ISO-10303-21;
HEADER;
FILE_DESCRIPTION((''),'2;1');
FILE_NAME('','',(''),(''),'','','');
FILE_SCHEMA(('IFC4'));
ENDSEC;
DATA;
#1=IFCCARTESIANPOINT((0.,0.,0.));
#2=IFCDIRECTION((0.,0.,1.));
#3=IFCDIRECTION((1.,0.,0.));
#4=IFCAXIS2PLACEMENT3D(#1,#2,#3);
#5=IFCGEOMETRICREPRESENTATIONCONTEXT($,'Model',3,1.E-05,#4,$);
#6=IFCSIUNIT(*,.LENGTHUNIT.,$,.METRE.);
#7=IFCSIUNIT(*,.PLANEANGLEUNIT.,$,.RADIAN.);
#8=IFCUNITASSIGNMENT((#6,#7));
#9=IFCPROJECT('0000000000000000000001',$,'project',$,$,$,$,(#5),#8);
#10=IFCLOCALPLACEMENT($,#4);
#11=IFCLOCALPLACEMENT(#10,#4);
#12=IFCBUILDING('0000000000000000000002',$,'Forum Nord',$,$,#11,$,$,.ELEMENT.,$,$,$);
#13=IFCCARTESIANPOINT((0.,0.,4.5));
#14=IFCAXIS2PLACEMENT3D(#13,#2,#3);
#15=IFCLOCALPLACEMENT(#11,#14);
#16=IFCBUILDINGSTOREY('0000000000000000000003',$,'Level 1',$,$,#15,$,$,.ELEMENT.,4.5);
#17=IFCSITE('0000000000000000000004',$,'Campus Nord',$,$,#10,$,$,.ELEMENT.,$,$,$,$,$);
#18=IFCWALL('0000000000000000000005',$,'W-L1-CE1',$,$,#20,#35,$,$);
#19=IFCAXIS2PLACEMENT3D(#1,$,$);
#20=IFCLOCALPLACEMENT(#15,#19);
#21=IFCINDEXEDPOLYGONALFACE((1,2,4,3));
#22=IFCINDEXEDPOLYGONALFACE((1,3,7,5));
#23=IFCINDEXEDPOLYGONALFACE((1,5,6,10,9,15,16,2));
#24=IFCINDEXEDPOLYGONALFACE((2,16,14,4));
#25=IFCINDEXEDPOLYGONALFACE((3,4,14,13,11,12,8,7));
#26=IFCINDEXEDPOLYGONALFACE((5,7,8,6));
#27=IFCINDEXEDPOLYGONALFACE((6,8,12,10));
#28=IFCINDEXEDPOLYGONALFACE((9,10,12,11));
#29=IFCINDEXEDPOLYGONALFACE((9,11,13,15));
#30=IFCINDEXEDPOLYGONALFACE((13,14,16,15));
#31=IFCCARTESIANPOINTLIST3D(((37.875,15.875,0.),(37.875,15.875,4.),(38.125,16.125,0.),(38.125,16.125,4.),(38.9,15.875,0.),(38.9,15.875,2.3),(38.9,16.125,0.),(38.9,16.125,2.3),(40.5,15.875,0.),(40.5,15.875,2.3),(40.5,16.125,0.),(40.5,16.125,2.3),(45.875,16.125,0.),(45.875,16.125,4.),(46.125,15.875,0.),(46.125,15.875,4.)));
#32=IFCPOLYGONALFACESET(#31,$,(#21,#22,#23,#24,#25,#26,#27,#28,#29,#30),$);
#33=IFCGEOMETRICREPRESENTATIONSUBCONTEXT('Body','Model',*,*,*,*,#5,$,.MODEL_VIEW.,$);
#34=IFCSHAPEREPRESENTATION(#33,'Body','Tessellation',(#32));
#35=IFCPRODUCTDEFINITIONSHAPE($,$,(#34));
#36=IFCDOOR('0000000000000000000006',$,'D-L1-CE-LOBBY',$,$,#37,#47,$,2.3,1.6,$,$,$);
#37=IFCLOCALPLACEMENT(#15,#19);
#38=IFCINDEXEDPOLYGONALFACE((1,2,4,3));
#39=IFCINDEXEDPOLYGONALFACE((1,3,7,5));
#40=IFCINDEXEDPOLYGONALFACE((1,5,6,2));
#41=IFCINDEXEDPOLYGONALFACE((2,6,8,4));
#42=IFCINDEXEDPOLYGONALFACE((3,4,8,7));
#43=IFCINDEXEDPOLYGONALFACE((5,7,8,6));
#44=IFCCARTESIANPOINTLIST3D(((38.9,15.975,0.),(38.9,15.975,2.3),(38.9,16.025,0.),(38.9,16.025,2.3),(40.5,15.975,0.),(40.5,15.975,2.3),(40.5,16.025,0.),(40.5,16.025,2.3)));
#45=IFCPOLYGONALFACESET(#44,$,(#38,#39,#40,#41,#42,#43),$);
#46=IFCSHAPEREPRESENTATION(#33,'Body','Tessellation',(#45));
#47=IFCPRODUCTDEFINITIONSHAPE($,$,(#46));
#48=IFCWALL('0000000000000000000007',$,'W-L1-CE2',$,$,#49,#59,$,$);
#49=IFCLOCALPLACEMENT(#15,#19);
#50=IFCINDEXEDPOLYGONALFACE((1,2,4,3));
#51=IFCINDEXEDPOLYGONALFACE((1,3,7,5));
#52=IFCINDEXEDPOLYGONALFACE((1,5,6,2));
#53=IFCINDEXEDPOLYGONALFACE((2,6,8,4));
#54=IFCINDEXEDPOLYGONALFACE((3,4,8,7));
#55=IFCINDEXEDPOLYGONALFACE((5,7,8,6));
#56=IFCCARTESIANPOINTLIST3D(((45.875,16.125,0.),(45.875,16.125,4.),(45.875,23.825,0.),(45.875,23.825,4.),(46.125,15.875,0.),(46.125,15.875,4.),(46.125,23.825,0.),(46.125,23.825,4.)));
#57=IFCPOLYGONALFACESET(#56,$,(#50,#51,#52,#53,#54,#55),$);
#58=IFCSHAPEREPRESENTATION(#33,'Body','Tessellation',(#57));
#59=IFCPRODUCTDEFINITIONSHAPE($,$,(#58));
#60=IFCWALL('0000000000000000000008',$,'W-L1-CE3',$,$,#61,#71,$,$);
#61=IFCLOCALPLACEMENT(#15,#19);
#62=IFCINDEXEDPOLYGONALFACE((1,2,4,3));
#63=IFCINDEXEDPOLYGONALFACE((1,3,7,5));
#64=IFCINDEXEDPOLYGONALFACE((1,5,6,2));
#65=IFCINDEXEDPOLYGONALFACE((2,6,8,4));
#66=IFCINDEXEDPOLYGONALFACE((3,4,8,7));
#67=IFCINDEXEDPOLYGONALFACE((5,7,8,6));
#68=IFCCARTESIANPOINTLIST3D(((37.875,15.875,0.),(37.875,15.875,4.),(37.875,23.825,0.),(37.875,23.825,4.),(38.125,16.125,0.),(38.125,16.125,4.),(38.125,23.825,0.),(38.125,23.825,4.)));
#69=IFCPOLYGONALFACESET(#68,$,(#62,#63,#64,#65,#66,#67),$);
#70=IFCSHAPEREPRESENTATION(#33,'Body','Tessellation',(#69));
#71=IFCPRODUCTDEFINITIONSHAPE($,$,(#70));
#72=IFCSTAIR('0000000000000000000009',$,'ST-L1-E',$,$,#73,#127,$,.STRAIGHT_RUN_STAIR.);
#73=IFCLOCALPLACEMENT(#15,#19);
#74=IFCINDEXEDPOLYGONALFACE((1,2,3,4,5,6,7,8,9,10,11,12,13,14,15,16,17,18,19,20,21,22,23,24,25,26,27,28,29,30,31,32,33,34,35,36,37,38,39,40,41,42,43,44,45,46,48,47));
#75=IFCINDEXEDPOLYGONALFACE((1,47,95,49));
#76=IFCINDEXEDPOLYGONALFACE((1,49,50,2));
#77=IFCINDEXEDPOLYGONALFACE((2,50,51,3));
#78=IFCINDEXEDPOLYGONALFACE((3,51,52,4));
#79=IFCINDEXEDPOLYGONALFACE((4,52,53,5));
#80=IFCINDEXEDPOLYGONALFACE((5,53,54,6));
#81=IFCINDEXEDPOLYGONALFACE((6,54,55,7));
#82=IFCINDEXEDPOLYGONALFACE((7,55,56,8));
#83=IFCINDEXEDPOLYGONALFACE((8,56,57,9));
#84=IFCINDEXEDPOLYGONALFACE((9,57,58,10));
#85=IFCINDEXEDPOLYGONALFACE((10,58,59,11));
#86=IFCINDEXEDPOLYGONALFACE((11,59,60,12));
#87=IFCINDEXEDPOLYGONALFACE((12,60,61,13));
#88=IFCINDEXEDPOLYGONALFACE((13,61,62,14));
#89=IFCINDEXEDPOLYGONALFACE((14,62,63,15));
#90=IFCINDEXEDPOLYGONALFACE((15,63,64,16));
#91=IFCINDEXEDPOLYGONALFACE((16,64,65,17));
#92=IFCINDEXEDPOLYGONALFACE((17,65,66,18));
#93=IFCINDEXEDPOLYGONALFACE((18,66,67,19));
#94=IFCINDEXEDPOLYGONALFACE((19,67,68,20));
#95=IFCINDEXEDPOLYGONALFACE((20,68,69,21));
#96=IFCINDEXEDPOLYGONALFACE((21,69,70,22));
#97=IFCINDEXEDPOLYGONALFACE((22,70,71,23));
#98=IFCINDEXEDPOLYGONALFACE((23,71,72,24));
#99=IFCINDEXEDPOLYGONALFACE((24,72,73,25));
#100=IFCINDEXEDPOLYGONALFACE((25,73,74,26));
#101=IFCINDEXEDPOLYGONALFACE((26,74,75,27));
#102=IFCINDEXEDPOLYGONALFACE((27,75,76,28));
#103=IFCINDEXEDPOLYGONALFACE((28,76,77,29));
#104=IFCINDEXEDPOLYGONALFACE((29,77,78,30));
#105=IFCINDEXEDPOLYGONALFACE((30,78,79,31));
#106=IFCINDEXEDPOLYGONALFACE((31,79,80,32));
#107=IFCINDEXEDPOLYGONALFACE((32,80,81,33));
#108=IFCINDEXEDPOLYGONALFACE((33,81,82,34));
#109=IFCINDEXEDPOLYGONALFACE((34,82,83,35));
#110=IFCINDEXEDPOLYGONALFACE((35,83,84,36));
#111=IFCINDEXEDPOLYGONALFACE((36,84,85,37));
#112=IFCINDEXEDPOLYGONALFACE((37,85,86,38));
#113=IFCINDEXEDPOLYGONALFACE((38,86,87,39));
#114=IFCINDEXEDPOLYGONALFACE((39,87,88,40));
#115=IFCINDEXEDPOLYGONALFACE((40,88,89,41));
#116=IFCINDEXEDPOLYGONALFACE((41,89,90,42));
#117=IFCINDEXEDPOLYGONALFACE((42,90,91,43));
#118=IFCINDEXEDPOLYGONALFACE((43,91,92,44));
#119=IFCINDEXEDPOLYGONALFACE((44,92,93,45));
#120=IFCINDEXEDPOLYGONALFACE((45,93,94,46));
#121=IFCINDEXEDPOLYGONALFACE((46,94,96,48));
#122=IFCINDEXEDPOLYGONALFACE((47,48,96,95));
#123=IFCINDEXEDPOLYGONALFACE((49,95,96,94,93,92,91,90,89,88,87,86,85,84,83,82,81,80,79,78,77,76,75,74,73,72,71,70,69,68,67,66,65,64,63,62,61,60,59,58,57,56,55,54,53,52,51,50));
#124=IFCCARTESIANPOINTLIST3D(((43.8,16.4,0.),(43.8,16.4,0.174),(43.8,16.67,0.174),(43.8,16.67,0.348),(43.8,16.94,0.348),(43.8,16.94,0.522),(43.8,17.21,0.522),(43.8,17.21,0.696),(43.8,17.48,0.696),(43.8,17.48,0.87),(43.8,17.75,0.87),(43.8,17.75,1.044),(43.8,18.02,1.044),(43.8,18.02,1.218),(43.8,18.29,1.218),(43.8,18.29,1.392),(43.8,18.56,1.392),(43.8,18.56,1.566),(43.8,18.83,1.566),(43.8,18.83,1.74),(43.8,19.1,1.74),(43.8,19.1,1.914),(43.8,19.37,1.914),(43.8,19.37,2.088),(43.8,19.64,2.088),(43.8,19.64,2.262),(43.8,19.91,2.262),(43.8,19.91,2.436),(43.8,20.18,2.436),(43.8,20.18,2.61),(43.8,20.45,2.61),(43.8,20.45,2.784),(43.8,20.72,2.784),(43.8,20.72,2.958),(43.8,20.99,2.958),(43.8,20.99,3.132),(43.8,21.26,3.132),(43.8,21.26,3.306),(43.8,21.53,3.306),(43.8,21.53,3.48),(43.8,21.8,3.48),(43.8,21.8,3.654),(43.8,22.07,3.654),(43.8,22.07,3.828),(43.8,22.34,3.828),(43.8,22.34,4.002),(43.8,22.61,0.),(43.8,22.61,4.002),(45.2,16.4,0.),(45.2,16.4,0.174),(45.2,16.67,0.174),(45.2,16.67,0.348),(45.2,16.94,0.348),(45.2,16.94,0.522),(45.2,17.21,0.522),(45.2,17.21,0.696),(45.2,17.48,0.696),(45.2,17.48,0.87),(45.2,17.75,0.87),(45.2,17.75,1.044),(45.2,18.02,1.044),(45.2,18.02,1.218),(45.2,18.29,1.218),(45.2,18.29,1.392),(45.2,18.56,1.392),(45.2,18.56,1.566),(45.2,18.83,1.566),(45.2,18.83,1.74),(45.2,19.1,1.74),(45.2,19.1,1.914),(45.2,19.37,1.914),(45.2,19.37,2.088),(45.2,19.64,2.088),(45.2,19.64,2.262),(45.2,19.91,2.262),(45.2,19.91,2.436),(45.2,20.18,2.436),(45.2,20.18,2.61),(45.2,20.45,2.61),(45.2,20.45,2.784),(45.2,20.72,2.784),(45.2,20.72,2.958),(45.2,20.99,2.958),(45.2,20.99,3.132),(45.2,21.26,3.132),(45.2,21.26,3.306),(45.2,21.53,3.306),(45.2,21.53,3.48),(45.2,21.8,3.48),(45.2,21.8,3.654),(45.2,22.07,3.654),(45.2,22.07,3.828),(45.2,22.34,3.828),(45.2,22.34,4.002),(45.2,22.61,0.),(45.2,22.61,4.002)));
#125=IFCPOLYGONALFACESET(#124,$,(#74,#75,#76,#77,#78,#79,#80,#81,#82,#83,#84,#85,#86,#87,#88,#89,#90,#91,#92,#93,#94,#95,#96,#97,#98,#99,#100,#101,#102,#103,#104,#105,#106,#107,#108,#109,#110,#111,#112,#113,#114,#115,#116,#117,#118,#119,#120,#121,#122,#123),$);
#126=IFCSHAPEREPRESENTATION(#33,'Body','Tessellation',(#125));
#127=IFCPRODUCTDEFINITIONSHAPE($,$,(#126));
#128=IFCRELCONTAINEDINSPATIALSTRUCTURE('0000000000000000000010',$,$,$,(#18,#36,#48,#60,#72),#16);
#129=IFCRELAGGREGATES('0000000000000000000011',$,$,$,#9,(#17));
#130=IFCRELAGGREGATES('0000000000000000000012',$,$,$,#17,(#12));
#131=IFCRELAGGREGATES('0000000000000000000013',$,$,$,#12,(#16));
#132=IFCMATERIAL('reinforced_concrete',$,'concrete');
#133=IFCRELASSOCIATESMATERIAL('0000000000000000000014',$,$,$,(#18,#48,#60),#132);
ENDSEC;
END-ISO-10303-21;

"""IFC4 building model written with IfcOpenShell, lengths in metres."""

from ifc_helpers import new_model, si_unit, frame, frame_2d, origin_with_axes, place, context, subcontext, project, spatial, polyline, rectangle, outline, extrude, material, element, fill, save


model = new_model("IFC4")

# Units and contexts
model_context = context("Model", 3, precision=1e-05, world=origin_with_axes())
body_context = subcontext(model_context, "Body", "Model", "MODEL_VIEW")
ifc_project = project(units=[si_unit("LENGTHUNIT", "METRE"), si_unit("PLANEANGLEUNIT", "RADIAN")], contexts=[model_context])

# Site, building, storey
site_placement = place(None, origin_with_axes())
site = spatial("IfcSite", under=ifc_project, at=site_placement, Name="Campus Nord", CompositionType="ELEMENT")
building_placement = place(site_placement, origin_with_axes())
building = spatial("IfcBuilding", under=site, at=building_placement, Name="Forum Nord", CompositionType="ELEMENT")
storey_placement = place(building_placement, frame((0.0, 0.0, 4.5), z_axis=(0.0, 0.0, 1.0), x_axis=(1.0, 0.0, 0.0)))
storey = spatial("IfcBuildingStorey", under=building, at=storey_placement, Name="Level 1", CompositionType="ELEMENT", Elevation=4.5)

# Wall, opening, door
ifc_material_1 = material(Name="reinforced_concrete", Category="concrete")
wall_1_placement = place(storey_placement, frame((38.0, 16.0, 0.0), z_axis=(0.0, 0.0, 1.0), x_axis=(1.0, 0.0, 0.0)))
wall_1 = element("IfcWall", 1, at=wall_1_placement, inside=storey, material=ifc_material_1, Name="W-L1-CE1", context=body_context, shape_type="SweptSolid", body=[
    extrude(outline(polyline([(-0.125, -0.125), (8.125, -0.125), (7.875, 0.125), (0.125, 0.125), (-0.125, -0.125)])), origin_with_axes(), (0.0, 0.0, 1.0), 4.0),
])
opening_1_placement = place(storey_placement, frame((38.0, 16.0, 0.0), z_axis=(0.0, 0.0, 1.0), x_axis=(1.0, 0.0, 0.0)))
opening_1 = element("IfcOpeningElement", 2, at=opening_1_placement, cuts=wall_1, context=body_context, shape_type="SweptSolid", body=[
    extrude(rectangle(XDim=1.6, YDim=0.25, at=frame_2d((1.7, 0.0), x_axis=(1.0, 0.0))), origin_with_axes(), (0.0, 0.0, 1.0), 2.3),
])
door_1_placement = place(storey_placement, frame((38.0, 16.0, 0.0), z_axis=(0.0, 0.0, 1.0), x_axis=(1.0, 0.0, 0.0)))
door_1 = element("IfcDoor", 3, at=door_1_placement, inside=storey, Name="D-L1-CE-LOBBY", OverallHeight=2.3, OverallWidth=1.6, context=body_context, shape_type="SweptSolid", body=[
    extrude(rectangle(XDim=1.6, YDim=0.05, at=frame_2d((1.7, 0.0), x_axis=(1.0, 0.0))), origin_with_axes(), (0.0, 0.0, 1.0), 2.3),
])
fill(opening_1, door_1)

# Walls
wall_2_placement = place(storey_placement, frame((46.0, 16.0, 0.0), z_axis=(0.0, 0.0, 1.0), x_axis=(0.0, 1.0, 0.0)))
element("IfcWall", 4, at=wall_2_placement, inside=storey, material=ifc_material_1, Name="W-L1-CE2", context=body_context, shape_type="SweptSolid", body=[
    extrude(outline(polyline([(-0.125, -0.125), (7.825, -0.125), (7.825, 0.125), (0.125, 0.125), (-0.125, -0.125)])), origin_with_axes(), (0.0, 0.0, 1.0), 4.0),
])
wall_3_placement = place(storey_placement, frame((38.0, 16.0, 0.0), z_axis=(0.0, 0.0, 1.0), x_axis=(0.0, 1.0, 0.0)))
element("IfcWall", 5, at=wall_3_placement, inside=storey, material=ifc_material_1, Name="W-L1-CE3", context=body_context, shape_type="SweptSolid", body=[
    extrude(outline(polyline([(0.125, -0.125), (7.825, -0.125), (7.825, 0.125), (-0.125, 0.125), (0.125, -0.125)])), origin_with_axes(), (0.0, 0.0, 1.0), 4.0),
])

# Stair
stair_placement = place(storey_placement, frame((43.8, 16.4, 0.0), z_axis=(0.0, 0.0, 1.0), x_axis=(1.0, 0.0, 0.0)))
element("IfcStair", 6, at=stair_placement, inside=storey, Name="ST-L1-E", PredefinedType="STRAIGHT_RUN_STAIR", context=body_context, shape_type="SweptSolid", body=[
    extrude(outline(polyline([(0.0, 0.0), (6.21, 0.0), (6.21, 4.002), (5.94, 4.002), (5.94, 3.828), (5.67, 3.828), (5.67, 3.654), (5.4, 3.654), (5.4, 3.48), (5.13, 3.48), (5.13, 3.306), (4.86, 3.306), (4.86, 3.132), (4.59, 3.132), (4.59, 2.958), (4.32, 2.958), (4.32, 2.784), (4.05, 2.784), (4.05, 2.61), (3.78, 2.61), (3.78, 2.436), (3.51, 2.436), (3.51, 2.262), (3.24, 2.262), (3.24, 2.088), (2.97, 2.088), (2.97, 1.914), (2.7, 1.914), (2.7, 1.74), (2.43, 1.74), (2.43, 1.566), (2.16, 1.566), (2.16, 1.392), (1.89, 1.392), (1.89, 1.218), (1.62, 1.218), (1.62, 1.044), (1.35, 1.044), (1.35, 0.87), (1.08, 0.87), (1.08, 0.696), (0.81, 0.696), (0.81, 0.522), (0.54, 0.522), (0.54, 0.348), (0.27, 0.348), (0.27, 0.174), (0.0, 0.174), (0.0, 0.0)])), frame((0.0, 0.0, 0.0), z_axis=(1.0, 0.0, 0.0), x_axis=(0.0, 1.0, 0.0)), (0.0, 0.0, 1.0), 1.4),
])

save(model, "model.ifc")
